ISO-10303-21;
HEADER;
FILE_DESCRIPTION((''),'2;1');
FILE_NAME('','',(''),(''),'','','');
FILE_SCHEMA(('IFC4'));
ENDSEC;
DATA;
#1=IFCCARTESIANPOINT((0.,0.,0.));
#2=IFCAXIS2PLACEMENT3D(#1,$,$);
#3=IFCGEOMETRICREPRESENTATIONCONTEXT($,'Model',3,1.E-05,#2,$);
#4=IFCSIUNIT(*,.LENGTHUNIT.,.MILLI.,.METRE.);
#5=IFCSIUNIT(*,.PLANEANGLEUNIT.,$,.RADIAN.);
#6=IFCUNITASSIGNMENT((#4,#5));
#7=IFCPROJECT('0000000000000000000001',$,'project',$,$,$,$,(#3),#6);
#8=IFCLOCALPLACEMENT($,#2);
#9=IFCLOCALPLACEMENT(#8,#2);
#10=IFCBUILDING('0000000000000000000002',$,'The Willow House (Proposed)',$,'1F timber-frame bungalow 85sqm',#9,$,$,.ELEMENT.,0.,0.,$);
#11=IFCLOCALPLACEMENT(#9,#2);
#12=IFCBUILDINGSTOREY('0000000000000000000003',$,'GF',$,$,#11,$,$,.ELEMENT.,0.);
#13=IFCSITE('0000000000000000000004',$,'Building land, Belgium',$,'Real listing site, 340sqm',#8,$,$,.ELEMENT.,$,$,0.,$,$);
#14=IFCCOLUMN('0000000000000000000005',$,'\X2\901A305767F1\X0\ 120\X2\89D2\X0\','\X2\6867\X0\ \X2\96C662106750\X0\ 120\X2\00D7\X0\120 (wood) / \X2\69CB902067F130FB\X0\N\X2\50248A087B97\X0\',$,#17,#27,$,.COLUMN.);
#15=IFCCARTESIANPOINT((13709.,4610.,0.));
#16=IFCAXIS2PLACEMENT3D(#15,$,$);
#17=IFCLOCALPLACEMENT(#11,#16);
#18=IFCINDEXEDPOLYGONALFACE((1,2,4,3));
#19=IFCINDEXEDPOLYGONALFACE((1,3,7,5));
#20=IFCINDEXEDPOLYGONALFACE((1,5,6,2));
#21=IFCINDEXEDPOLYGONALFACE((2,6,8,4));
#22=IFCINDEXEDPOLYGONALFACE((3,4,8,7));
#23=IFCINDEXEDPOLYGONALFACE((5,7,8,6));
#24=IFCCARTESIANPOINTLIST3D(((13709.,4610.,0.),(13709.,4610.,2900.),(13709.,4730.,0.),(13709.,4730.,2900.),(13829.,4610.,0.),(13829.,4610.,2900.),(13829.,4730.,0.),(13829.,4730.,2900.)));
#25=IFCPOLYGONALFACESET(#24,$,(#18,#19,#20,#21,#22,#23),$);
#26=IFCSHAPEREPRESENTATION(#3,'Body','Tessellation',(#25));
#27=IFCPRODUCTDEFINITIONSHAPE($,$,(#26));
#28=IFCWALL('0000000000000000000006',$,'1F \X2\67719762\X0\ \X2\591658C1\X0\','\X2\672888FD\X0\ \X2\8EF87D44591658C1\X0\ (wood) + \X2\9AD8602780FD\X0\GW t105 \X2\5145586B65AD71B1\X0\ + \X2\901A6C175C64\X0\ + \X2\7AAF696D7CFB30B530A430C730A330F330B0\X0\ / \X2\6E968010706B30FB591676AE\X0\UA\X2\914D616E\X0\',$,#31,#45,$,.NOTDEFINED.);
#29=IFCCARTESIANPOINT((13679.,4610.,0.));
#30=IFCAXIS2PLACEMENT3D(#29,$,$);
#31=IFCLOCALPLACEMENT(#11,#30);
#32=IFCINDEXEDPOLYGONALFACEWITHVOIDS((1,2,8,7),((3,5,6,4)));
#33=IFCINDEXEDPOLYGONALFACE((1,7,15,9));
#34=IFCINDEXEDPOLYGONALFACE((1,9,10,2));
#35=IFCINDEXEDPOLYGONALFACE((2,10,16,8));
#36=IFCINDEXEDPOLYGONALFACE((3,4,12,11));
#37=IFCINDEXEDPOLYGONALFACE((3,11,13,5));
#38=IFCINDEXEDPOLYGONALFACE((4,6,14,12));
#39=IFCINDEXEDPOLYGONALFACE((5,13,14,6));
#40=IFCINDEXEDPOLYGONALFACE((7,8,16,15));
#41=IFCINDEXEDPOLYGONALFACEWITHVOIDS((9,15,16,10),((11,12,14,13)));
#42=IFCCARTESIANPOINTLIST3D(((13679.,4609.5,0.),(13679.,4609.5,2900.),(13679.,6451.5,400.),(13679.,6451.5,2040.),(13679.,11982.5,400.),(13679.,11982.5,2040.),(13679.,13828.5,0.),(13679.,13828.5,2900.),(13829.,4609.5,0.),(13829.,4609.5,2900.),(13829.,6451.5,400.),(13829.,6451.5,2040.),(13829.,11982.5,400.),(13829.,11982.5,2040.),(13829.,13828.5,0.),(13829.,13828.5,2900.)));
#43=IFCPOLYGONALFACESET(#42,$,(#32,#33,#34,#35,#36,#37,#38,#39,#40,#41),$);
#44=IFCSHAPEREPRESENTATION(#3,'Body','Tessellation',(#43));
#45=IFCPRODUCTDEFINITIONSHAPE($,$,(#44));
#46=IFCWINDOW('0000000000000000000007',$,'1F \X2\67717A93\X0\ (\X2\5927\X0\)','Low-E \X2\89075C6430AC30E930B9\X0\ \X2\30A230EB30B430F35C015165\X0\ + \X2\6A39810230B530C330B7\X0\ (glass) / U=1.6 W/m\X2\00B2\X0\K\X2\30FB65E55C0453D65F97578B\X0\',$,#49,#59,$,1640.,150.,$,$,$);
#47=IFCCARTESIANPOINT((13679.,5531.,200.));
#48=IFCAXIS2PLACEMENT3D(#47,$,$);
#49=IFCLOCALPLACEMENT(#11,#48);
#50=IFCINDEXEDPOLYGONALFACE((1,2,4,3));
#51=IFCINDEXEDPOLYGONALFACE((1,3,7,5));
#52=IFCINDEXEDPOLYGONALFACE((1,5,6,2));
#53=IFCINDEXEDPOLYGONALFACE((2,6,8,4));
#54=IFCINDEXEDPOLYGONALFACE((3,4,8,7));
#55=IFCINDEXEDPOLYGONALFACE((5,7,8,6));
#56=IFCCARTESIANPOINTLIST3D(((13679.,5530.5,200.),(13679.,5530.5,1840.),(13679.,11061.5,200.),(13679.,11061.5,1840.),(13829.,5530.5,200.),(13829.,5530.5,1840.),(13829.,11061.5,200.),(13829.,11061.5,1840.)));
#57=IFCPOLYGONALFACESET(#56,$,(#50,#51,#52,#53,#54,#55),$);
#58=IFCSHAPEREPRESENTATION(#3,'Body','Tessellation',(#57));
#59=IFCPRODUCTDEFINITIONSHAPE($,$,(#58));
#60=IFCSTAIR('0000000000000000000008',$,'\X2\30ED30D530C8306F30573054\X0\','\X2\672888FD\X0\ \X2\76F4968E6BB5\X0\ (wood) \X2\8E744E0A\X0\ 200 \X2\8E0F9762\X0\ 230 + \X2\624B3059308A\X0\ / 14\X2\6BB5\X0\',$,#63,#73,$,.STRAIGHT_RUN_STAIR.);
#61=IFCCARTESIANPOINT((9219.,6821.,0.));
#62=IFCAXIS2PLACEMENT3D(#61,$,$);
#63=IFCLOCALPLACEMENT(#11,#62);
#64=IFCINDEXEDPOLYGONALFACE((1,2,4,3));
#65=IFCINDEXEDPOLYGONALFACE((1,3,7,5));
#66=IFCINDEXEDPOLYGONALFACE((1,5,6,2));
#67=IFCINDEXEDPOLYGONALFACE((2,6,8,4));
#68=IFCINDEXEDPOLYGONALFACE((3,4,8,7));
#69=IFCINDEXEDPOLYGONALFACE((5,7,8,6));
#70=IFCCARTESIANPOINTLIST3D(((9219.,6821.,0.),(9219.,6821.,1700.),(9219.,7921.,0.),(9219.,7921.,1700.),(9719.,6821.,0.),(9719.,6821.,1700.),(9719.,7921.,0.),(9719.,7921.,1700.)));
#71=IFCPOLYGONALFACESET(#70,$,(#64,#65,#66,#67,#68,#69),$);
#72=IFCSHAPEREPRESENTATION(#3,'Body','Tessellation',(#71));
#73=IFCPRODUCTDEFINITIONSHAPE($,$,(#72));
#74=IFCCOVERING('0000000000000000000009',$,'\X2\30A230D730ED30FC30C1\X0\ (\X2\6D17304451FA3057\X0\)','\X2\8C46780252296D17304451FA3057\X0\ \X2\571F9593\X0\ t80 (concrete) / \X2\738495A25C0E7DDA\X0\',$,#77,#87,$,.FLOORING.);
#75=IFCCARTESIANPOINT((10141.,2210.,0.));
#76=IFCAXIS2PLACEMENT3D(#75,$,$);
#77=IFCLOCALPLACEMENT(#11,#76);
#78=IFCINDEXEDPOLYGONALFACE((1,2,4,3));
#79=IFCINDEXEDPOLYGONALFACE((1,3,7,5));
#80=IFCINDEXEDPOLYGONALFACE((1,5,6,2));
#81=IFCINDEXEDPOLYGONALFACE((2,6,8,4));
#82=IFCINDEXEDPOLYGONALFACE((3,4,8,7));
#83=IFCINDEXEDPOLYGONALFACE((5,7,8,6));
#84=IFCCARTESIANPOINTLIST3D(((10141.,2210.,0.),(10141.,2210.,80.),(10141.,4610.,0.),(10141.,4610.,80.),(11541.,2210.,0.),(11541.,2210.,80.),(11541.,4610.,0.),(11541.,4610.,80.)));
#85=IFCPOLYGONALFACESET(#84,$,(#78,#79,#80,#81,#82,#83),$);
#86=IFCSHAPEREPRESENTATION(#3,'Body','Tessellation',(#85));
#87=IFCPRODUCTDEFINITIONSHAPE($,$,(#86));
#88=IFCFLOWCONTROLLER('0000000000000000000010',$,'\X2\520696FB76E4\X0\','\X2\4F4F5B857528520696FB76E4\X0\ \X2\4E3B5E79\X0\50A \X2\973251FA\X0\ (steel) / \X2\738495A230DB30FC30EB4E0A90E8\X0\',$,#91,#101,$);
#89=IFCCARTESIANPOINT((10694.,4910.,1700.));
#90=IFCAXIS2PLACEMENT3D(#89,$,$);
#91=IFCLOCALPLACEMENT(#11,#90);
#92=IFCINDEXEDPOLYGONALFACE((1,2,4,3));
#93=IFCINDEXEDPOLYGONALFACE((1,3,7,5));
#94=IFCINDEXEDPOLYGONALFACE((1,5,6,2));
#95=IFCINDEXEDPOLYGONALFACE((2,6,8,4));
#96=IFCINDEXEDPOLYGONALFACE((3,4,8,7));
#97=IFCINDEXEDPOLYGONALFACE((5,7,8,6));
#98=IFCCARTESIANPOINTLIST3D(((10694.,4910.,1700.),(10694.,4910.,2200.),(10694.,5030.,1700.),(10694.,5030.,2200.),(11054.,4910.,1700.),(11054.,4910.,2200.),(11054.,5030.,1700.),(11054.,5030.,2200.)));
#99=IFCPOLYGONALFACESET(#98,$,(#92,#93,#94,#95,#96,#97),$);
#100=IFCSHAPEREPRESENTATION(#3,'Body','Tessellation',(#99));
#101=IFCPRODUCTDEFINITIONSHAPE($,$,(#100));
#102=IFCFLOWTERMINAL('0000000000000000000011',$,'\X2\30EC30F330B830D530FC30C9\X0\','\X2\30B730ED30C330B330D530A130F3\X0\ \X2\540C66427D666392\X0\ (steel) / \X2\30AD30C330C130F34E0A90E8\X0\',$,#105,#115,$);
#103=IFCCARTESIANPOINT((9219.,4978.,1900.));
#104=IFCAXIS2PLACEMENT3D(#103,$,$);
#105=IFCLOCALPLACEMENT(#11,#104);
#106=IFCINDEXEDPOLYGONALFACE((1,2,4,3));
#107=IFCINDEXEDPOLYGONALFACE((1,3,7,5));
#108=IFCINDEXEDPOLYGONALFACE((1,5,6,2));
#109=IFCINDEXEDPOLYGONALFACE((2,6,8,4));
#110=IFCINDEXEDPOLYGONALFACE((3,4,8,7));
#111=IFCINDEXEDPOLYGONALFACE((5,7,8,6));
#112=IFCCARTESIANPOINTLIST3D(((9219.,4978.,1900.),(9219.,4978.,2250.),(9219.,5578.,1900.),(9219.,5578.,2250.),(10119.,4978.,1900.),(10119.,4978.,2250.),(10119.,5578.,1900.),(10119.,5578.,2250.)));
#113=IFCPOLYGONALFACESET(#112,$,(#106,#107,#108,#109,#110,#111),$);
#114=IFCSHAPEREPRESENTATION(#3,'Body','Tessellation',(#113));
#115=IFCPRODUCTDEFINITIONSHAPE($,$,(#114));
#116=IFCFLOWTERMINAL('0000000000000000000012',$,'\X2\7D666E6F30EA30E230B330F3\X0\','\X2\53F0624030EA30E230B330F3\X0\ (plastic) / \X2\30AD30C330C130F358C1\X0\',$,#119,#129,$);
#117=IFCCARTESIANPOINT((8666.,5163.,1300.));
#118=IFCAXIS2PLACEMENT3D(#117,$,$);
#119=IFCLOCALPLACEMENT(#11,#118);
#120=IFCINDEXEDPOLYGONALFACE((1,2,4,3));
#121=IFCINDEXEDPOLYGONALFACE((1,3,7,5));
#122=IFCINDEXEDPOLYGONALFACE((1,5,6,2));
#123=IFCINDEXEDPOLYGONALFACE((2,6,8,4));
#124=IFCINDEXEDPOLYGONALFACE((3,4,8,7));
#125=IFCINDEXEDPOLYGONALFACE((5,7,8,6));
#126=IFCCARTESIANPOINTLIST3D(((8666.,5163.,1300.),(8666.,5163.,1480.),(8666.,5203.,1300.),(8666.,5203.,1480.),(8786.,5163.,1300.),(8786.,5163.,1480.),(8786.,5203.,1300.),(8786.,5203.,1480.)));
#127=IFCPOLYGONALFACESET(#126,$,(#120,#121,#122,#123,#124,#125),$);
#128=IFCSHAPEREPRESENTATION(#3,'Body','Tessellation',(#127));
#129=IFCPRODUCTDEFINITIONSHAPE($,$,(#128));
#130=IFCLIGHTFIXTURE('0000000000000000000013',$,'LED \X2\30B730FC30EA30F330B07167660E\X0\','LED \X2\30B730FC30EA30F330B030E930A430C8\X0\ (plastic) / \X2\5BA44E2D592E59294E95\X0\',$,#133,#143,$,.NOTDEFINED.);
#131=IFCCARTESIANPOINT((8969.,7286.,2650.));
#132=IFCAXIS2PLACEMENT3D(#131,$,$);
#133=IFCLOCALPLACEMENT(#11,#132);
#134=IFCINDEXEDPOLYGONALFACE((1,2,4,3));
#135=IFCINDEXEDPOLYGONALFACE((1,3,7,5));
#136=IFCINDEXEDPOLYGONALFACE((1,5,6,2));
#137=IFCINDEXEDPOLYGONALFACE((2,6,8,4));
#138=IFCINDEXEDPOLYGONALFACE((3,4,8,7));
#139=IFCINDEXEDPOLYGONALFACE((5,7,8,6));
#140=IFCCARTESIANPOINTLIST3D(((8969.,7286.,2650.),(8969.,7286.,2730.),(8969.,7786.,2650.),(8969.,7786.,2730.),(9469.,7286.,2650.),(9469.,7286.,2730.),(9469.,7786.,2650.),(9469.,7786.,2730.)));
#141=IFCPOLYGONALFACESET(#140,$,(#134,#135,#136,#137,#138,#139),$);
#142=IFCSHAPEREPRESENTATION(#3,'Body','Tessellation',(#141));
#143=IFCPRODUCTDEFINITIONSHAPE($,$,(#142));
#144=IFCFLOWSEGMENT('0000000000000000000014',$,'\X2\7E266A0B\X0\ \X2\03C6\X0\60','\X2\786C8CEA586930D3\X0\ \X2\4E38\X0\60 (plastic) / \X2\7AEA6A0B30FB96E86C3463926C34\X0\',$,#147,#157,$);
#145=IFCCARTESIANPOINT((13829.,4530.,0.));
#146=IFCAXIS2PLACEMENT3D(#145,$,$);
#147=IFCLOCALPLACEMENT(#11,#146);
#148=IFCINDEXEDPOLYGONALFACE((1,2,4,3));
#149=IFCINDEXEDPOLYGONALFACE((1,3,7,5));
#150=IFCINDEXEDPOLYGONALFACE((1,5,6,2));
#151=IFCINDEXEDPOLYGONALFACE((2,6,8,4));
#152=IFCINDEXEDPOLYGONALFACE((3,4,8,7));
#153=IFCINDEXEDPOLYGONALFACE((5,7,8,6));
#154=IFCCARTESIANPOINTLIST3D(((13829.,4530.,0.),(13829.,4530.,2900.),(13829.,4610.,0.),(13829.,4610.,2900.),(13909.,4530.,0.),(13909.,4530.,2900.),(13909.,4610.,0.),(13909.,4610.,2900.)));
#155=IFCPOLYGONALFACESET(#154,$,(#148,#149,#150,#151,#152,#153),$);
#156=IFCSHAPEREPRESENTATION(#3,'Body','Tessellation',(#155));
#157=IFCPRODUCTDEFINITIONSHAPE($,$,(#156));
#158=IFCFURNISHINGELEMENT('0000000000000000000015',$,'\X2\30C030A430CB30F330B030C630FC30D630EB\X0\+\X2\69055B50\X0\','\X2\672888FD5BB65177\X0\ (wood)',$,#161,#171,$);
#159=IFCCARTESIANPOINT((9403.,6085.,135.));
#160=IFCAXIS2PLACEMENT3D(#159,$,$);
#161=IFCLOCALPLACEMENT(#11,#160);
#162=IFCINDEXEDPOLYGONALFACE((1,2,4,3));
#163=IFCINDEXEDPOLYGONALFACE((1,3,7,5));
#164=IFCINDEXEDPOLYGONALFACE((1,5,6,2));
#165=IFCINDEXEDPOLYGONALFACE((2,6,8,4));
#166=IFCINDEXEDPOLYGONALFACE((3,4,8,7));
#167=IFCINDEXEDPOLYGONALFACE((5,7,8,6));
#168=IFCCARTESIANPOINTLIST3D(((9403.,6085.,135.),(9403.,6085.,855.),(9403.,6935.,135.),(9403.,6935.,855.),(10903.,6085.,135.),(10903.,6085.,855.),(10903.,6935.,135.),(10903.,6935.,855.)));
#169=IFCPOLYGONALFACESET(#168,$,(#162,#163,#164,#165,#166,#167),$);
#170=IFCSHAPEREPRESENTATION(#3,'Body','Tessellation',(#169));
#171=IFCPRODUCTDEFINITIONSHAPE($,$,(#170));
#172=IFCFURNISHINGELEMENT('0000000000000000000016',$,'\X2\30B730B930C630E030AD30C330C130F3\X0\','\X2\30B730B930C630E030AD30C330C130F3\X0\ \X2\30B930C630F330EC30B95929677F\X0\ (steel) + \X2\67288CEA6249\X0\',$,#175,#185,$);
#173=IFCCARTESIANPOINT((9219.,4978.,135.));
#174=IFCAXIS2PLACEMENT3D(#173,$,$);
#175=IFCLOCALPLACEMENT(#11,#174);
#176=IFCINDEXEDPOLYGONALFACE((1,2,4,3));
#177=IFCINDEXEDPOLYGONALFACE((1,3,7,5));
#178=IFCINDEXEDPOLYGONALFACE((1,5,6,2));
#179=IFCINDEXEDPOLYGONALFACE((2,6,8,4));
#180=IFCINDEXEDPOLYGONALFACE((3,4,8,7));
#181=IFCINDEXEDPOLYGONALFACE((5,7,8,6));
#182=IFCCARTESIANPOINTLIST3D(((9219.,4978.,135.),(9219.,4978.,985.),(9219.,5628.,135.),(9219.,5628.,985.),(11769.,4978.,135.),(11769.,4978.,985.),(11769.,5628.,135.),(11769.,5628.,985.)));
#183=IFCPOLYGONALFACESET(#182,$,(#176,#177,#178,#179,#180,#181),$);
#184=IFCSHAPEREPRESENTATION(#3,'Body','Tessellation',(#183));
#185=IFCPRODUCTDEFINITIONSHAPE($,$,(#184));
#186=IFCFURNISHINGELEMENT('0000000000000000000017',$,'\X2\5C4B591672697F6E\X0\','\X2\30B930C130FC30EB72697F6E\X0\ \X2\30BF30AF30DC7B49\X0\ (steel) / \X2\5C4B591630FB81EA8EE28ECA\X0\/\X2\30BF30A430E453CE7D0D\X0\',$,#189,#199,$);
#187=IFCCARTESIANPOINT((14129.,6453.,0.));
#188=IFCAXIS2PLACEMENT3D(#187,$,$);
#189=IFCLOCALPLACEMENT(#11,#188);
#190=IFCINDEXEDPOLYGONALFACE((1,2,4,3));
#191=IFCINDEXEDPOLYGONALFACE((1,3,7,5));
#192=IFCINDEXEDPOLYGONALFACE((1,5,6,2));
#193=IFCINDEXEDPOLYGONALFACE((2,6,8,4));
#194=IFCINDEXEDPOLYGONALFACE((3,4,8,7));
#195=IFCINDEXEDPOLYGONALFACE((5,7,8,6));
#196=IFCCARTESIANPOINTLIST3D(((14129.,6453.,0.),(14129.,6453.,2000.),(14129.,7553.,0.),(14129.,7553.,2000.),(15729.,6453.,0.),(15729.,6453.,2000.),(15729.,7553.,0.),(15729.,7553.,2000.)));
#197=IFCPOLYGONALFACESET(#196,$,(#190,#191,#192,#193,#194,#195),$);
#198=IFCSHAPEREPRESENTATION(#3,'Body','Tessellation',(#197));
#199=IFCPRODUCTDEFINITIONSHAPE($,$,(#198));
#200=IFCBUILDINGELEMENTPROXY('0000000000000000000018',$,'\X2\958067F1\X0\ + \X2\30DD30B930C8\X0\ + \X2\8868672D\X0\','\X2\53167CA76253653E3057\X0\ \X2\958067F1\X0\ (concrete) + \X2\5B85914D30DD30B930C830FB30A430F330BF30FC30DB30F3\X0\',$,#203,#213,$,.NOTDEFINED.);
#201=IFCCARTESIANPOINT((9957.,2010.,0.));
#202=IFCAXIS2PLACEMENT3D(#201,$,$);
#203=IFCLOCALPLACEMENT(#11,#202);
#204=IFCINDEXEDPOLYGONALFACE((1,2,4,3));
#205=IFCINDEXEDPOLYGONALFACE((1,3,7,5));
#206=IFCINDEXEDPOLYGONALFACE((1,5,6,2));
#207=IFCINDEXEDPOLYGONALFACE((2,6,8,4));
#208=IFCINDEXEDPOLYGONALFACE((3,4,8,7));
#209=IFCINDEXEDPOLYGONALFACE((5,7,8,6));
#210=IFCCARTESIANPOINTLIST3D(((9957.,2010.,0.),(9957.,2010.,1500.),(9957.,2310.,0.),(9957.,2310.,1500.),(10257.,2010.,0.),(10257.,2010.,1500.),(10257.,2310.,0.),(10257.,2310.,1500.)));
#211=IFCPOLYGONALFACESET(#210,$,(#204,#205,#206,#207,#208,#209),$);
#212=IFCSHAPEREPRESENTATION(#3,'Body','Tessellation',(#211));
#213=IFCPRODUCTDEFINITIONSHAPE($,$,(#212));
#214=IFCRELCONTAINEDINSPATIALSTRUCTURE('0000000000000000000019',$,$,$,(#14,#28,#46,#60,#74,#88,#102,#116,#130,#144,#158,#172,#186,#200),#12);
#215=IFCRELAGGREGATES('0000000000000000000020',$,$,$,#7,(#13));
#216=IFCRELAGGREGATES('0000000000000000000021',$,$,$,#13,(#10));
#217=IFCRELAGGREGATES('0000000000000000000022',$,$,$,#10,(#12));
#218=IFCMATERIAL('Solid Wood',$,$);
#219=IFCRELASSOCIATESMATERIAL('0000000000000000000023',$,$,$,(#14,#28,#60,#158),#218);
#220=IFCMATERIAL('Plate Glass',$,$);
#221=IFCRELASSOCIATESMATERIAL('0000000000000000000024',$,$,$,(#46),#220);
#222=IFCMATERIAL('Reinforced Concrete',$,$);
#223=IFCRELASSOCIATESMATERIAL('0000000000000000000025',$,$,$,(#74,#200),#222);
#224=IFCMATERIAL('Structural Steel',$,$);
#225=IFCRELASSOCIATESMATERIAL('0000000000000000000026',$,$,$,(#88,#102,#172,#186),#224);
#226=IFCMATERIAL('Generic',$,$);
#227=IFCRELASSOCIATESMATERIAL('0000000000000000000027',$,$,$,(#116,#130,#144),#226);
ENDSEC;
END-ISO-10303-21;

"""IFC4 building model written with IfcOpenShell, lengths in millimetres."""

from ifc_helpers import new_model, si_unit, frame, frame_2d, origin, place, context, project, spatial, rectangle, extrude, material, element, fill, save


model = new_model("IFC4")

# Units and contexts
model_context = context("Model", 3, precision=1e-05, world=origin())
ifc_project = project(units=[si_unit("LENGTHUNIT", "METRE", prefix="MILLI"), si_unit("PLANEANGLEUNIT", "RADIAN")], contexts=[model_context])

# Site, building, storey
site_placement = place(None, origin())
site = spatial("IfcSite", under=ifc_project, at=site_placement, Name="Building land, Belgium", ObjectType="Real listing site, 340sqm", CompositionType="ELEMENT", RefElevation=0.0)
building_placement = place(site_placement, origin())
building = spatial("IfcBuilding", under=site, at=building_placement, Name="The Willow House (Proposed)", ObjectType="1F timber-frame bungalow 85sqm", CompositionType="ELEMENT", ElevationOfRefHeight=0.0, ElevationOfTerrain=0.0)
storey_placement = place(building_placement, origin())
storey = spatial("IfcBuildingStorey", under=building, at=storey_placement, Name="GF", CompositionType="ELEMENT", Elevation=0.0)

# Column
ifc_material_1 = material(Name="Solid Wood")
column_1_placement = place(storey_placement, frame((13709.0, 4610.0, 0.0)))
element("IfcColumn", 1, at=column_1_placement, inside=storey, material=ifc_material_1, Name="通し柱 120角", Description="桧 集成材 120×120 (wood) / 構造柱・N値計算", PredefinedType="COLUMN", context=model_context, shape_type="SweptSolid", body=[
    extrude(rectangle(XDim=120.0, YDim=120.0, at=frame_2d((60.0, 60.0))), frame((13709.0, 4610.0, 0.0)), (0.0, 0.0, 1.0), 2900.0),
])

# Wall, opening, window
wall_1_placement = place(storey_placement, frame((13679.0, 4610.0, 0.0)))
wall_1 = element("IfcWall", 2, at=wall_1_placement, inside=storey, material=ifc_material_1, Name="1F 東面 外壁", Description="木製 軸組外壁 (wood) + 高性能GW t105 充填断熱 + 通気層 + 窯業系サイディング / 準耐火・外皮UA配慮", PredefinedType="NOTDEFINED", context=model_context, shape_type="SweptSolid", body=[
    extrude(rectangle(XDim=150.0, YDim=9219.0, at=frame_2d((75.0, 4609.0))), frame((13679.0, 4610.0, 0.0)), (0.0, 0.0, 1.0), 2900.0),
])
opening_placement = place(storey_placement, frame((13679.0, 5531.0, 200.0)))
opening = element("IfcOpeningElement", 3, at=opening_placement, cuts=wall_1, PredefinedType="NOTDEFINED", context=model_context, shape_type="SweptSolid", body=[
    extrude(rectangle(XDim=150.0, YDim=5531.0, at=frame_2d((75.0, 2765.0))), frame((13679.0, 5531.0, 200.0)), (0.0, 0.0, 1.0), 1640.0),
])
ifc_material_2 = material(Name="Plate Glass")
window_placement = place(storey_placement, frame((13679.0, 5531.0, 200.0)))
window = element("IfcWindow", 4, at=window_placement, inside=storey, material=ifc_material_2, Name="1F 東窓 (大)", Description="Low-E 複層ガラス アルゴン封入 + 樹脂サッシ (glass) / U=1.6 W/m²K・日射取得型", OverallHeight=1640.0, OverallWidth=150.0, context=model_context, shape_type="SweptSolid", body=[
    extrude(rectangle(XDim=150.0, YDim=5531.0, at=frame_2d((75.0, 2765.0))), frame((13679.0, 5531.0, 200.0)), (0.0, 0.0, 1.0), 1640.0),
])
fill(opening, window)

# Stair
stair_placement = place(storey_placement, frame((9219.0, 6821.0, 0.0)))
element("IfcStair", 5, at=stair_placement, inside=storey, material=ifc_material_1, Name="ロフトはしご", Description="木製 直階段 (wood) 蹴上 200 踏面 230 + 手すり / 14段", PredefinedType="STRAIGHT_RUN_STAIR", context=model_context, shape_type="SweptSolid", body=[
    extrude(rectangle(XDim=500.0, YDim=1100.0, at=frame_2d((250.0, 550.0))), frame((9219.0, 6821.0, 0.0)), (0.0, 0.0, 1.0), 1700.0),
])

# Covering
ifc_material_3 = material(Name="Reinforced Concrete")
covering_placement = place(storey_placement, frame((10141.0, 2210.0, 0.0)))
element("IfcCovering", 6, at=covering_placement, inside=storey, material=ifc_material_3, Name="アプローチ (洗い出し)", Description="豆砂利洗い出し 土間 t80 (concrete) / 玄関導線", PredefinedType="FLOORING", context=model_context, shape_type="SweptSolid", body=[
    extrude(rectangle(XDim=1400.0, YDim=2400.0, at=frame_2d((700.0, 1200.0))), frame((10141.0, 2210.0, 0.0)), (0.0, 0.0, 1.0), 80.0),
])

# Flow controller
ifc_material_4 = material(Name="Structural Steel")
flow_controller_placement = place(storey_placement, frame((10694.0, 4910.0, 1700.0)))
element("IfcFlowController", 7, at=flow_controller_placement, inside=storey, material=ifc_material_4, Name="分電盤", Description="住宅用分電盤 主幹50A 露出 (steel) / 玄関ホール上部", context=model_context, shape_type="SweptSolid", body=[
    extrude(rectangle(XDim=360.0, YDim=120.0, at=frame_2d((180.0, 60.0))), frame((10694.0, 4910.0, 1700.0)), (0.0, 0.0, 1.0), 500.0),
])

# Flow terminals
flow_terminal_1_placement = place(storey_placement, frame((9219.0, 4978.0, 1900.0)))
element("IfcFlowTerminal", 8, at=flow_terminal_1_placement, inside=storey, material=ifc_material_4, Name="レンジフード", Description="シロッコファン 同時給排 (steel) / キッチン上部", context=model_context, shape_type="SweptSolid", body=[
    extrude(rectangle(XDim=900.0, YDim=600.0, at=frame_2d((450.0, 300.0))), frame((9219.0, 4978.0, 1900.0)), (0.0, 0.0, 1.0), 350.0),
])
ifc_material_5 = material(Name="Generic")
flow_terminal_2_placement = place(storey_placement, frame((8666.0, 5163.0, 1300.0)))
element("IfcFlowTerminal", 9, at=flow_terminal_2_placement, inside=storey, material=ifc_material_5, Name="給湯リモコン", Description="台所リモコン (plastic) / キッチン壁", context=model_context, shape_type="SweptSolid", body=[
    extrude(rectangle(XDim=120.0, YDim=40.0, at=frame_2d((60.0, 20.0))), frame((8666.0, 5163.0, 1300.0)), (0.0, 0.0, 1.0), 180.0),
])

# Light fixture
light_fixture_placement = place(storey_placement, frame((8969.0, 7286.0, 2650.0)))
element("IfcLightFixture", 10, at=light_fixture_placement, inside=storey, material=ifc_material_5, Name="LED シーリング照明", Description="LED シーリングライト (plastic) / 室中央天井", PredefinedType="NOTDEFINED", context=model_context, shape_type="SweptSolid", body=[
    extrude(rectangle(XDim=500.0, YDim=500.0, at=frame_2d((250.0, 250.0))), frame((8969.0, 7286.0, 2650.0)), (0.0, 0.0, 1.0), 80.0),
])

# Flow segment
flow_segment_placement = place(storey_placement, frame((13829.0, 4530.0, 0.0)))
element("IfcFlowSegment", 11, at=flow_segment_placement, inside=storey, material=ifc_material_5, Name="縦樋 φ60", Description="硬質塩ビ 丸60 (plastic) / 竪樋・雨水排水", context=model_context, shape_type="SweptSolid", body=[
    extrude(rectangle(XDim=80.0, YDim=80.0, at=frame_2d((40.0, 40.0))), frame((13829.0, 4530.0, 0.0)), (0.0, 0.0, 1.0), 2900.0),
])

# Furnishing elements
furnishing_1_placement = place(storey_placement, frame((9403.0, 6085.0, 135.0)))
element("IfcFurnishingElement", 12, at=furnishing_1_placement, inside=storey, material=ifc_material_1, Name="ダイニングテーブル+椅子", Description="木製家具 (wood)", context=model_context, shape_type="SweptSolid", body=[
    extrude(rectangle(XDim=1500.0, YDim=850.0, at=frame_2d((750.0, 425.0))), frame((9403.0, 6085.0, 135.0)), (0.0, 0.0, 1.0), 720.0),
])
furnishing_2_placement = place(storey_placement, frame((9219.0, 4978.0, 135.0)))
element("IfcFurnishingElement", 13, at=furnishing_2_placement, inside=storey, material=ifc_material_4, Name="システムキッチン", Description="システムキッチン ステンレス天板 (steel) + 木質扉", context=model_context, shape_type="SweptSolid", body=[
    extrude(rectangle(XDim=2550.0, YDim=650.0, at=frame_2d((1275.0, 325.0))), frame((9219.0, 4978.0, 135.0)), (0.0, 0.0, 1.0), 850.0),
])
furnishing_3_placement = place(storey_placement, frame((14129.0, 6453.0, 0.0)))
element("IfcFurnishingElement", 14, at=furnishing_3_placement, inside=storey, material=ifc_material_4, Name="屋外物置", Description="スチール物置 タクボ等 (steel) / 屋外・自転車/タイヤ収納", context=model_context, shape_type="SweptSolid", body=[
    extrude(rectangle(XDim=1600.0, YDim=1100.0, at=frame_2d((800.0, 550.0))), frame((14129.0, 6453.0, 0.0)), (0.0, 0.0, 1.0), 2000.0),
])

# Building element proxy
proxy_placement = place(storey_placement, frame((9957.0, 2010.0, 0.0)))
element("IfcBuildingElementProxy", 15, at=proxy_placement, inside=storey, material=ifc_material_3, Name="門柱 + ポスト + 表札", Description="化粧打放し 門柱 (concrete) + 宅配ポスト・インターホン", PredefinedType="NOTDEFINED", context=model_context, shape_type="SweptSolid", body=[
    extrude(rectangle(XDim=300.0, YDim=300.0, at=frame_2d((150.0, 150.0))), frame((9957.0, 2010.0, 0.0)), (0.0, 0.0, 1.0), 1500.0),
])

save(model, "model.ifc")
